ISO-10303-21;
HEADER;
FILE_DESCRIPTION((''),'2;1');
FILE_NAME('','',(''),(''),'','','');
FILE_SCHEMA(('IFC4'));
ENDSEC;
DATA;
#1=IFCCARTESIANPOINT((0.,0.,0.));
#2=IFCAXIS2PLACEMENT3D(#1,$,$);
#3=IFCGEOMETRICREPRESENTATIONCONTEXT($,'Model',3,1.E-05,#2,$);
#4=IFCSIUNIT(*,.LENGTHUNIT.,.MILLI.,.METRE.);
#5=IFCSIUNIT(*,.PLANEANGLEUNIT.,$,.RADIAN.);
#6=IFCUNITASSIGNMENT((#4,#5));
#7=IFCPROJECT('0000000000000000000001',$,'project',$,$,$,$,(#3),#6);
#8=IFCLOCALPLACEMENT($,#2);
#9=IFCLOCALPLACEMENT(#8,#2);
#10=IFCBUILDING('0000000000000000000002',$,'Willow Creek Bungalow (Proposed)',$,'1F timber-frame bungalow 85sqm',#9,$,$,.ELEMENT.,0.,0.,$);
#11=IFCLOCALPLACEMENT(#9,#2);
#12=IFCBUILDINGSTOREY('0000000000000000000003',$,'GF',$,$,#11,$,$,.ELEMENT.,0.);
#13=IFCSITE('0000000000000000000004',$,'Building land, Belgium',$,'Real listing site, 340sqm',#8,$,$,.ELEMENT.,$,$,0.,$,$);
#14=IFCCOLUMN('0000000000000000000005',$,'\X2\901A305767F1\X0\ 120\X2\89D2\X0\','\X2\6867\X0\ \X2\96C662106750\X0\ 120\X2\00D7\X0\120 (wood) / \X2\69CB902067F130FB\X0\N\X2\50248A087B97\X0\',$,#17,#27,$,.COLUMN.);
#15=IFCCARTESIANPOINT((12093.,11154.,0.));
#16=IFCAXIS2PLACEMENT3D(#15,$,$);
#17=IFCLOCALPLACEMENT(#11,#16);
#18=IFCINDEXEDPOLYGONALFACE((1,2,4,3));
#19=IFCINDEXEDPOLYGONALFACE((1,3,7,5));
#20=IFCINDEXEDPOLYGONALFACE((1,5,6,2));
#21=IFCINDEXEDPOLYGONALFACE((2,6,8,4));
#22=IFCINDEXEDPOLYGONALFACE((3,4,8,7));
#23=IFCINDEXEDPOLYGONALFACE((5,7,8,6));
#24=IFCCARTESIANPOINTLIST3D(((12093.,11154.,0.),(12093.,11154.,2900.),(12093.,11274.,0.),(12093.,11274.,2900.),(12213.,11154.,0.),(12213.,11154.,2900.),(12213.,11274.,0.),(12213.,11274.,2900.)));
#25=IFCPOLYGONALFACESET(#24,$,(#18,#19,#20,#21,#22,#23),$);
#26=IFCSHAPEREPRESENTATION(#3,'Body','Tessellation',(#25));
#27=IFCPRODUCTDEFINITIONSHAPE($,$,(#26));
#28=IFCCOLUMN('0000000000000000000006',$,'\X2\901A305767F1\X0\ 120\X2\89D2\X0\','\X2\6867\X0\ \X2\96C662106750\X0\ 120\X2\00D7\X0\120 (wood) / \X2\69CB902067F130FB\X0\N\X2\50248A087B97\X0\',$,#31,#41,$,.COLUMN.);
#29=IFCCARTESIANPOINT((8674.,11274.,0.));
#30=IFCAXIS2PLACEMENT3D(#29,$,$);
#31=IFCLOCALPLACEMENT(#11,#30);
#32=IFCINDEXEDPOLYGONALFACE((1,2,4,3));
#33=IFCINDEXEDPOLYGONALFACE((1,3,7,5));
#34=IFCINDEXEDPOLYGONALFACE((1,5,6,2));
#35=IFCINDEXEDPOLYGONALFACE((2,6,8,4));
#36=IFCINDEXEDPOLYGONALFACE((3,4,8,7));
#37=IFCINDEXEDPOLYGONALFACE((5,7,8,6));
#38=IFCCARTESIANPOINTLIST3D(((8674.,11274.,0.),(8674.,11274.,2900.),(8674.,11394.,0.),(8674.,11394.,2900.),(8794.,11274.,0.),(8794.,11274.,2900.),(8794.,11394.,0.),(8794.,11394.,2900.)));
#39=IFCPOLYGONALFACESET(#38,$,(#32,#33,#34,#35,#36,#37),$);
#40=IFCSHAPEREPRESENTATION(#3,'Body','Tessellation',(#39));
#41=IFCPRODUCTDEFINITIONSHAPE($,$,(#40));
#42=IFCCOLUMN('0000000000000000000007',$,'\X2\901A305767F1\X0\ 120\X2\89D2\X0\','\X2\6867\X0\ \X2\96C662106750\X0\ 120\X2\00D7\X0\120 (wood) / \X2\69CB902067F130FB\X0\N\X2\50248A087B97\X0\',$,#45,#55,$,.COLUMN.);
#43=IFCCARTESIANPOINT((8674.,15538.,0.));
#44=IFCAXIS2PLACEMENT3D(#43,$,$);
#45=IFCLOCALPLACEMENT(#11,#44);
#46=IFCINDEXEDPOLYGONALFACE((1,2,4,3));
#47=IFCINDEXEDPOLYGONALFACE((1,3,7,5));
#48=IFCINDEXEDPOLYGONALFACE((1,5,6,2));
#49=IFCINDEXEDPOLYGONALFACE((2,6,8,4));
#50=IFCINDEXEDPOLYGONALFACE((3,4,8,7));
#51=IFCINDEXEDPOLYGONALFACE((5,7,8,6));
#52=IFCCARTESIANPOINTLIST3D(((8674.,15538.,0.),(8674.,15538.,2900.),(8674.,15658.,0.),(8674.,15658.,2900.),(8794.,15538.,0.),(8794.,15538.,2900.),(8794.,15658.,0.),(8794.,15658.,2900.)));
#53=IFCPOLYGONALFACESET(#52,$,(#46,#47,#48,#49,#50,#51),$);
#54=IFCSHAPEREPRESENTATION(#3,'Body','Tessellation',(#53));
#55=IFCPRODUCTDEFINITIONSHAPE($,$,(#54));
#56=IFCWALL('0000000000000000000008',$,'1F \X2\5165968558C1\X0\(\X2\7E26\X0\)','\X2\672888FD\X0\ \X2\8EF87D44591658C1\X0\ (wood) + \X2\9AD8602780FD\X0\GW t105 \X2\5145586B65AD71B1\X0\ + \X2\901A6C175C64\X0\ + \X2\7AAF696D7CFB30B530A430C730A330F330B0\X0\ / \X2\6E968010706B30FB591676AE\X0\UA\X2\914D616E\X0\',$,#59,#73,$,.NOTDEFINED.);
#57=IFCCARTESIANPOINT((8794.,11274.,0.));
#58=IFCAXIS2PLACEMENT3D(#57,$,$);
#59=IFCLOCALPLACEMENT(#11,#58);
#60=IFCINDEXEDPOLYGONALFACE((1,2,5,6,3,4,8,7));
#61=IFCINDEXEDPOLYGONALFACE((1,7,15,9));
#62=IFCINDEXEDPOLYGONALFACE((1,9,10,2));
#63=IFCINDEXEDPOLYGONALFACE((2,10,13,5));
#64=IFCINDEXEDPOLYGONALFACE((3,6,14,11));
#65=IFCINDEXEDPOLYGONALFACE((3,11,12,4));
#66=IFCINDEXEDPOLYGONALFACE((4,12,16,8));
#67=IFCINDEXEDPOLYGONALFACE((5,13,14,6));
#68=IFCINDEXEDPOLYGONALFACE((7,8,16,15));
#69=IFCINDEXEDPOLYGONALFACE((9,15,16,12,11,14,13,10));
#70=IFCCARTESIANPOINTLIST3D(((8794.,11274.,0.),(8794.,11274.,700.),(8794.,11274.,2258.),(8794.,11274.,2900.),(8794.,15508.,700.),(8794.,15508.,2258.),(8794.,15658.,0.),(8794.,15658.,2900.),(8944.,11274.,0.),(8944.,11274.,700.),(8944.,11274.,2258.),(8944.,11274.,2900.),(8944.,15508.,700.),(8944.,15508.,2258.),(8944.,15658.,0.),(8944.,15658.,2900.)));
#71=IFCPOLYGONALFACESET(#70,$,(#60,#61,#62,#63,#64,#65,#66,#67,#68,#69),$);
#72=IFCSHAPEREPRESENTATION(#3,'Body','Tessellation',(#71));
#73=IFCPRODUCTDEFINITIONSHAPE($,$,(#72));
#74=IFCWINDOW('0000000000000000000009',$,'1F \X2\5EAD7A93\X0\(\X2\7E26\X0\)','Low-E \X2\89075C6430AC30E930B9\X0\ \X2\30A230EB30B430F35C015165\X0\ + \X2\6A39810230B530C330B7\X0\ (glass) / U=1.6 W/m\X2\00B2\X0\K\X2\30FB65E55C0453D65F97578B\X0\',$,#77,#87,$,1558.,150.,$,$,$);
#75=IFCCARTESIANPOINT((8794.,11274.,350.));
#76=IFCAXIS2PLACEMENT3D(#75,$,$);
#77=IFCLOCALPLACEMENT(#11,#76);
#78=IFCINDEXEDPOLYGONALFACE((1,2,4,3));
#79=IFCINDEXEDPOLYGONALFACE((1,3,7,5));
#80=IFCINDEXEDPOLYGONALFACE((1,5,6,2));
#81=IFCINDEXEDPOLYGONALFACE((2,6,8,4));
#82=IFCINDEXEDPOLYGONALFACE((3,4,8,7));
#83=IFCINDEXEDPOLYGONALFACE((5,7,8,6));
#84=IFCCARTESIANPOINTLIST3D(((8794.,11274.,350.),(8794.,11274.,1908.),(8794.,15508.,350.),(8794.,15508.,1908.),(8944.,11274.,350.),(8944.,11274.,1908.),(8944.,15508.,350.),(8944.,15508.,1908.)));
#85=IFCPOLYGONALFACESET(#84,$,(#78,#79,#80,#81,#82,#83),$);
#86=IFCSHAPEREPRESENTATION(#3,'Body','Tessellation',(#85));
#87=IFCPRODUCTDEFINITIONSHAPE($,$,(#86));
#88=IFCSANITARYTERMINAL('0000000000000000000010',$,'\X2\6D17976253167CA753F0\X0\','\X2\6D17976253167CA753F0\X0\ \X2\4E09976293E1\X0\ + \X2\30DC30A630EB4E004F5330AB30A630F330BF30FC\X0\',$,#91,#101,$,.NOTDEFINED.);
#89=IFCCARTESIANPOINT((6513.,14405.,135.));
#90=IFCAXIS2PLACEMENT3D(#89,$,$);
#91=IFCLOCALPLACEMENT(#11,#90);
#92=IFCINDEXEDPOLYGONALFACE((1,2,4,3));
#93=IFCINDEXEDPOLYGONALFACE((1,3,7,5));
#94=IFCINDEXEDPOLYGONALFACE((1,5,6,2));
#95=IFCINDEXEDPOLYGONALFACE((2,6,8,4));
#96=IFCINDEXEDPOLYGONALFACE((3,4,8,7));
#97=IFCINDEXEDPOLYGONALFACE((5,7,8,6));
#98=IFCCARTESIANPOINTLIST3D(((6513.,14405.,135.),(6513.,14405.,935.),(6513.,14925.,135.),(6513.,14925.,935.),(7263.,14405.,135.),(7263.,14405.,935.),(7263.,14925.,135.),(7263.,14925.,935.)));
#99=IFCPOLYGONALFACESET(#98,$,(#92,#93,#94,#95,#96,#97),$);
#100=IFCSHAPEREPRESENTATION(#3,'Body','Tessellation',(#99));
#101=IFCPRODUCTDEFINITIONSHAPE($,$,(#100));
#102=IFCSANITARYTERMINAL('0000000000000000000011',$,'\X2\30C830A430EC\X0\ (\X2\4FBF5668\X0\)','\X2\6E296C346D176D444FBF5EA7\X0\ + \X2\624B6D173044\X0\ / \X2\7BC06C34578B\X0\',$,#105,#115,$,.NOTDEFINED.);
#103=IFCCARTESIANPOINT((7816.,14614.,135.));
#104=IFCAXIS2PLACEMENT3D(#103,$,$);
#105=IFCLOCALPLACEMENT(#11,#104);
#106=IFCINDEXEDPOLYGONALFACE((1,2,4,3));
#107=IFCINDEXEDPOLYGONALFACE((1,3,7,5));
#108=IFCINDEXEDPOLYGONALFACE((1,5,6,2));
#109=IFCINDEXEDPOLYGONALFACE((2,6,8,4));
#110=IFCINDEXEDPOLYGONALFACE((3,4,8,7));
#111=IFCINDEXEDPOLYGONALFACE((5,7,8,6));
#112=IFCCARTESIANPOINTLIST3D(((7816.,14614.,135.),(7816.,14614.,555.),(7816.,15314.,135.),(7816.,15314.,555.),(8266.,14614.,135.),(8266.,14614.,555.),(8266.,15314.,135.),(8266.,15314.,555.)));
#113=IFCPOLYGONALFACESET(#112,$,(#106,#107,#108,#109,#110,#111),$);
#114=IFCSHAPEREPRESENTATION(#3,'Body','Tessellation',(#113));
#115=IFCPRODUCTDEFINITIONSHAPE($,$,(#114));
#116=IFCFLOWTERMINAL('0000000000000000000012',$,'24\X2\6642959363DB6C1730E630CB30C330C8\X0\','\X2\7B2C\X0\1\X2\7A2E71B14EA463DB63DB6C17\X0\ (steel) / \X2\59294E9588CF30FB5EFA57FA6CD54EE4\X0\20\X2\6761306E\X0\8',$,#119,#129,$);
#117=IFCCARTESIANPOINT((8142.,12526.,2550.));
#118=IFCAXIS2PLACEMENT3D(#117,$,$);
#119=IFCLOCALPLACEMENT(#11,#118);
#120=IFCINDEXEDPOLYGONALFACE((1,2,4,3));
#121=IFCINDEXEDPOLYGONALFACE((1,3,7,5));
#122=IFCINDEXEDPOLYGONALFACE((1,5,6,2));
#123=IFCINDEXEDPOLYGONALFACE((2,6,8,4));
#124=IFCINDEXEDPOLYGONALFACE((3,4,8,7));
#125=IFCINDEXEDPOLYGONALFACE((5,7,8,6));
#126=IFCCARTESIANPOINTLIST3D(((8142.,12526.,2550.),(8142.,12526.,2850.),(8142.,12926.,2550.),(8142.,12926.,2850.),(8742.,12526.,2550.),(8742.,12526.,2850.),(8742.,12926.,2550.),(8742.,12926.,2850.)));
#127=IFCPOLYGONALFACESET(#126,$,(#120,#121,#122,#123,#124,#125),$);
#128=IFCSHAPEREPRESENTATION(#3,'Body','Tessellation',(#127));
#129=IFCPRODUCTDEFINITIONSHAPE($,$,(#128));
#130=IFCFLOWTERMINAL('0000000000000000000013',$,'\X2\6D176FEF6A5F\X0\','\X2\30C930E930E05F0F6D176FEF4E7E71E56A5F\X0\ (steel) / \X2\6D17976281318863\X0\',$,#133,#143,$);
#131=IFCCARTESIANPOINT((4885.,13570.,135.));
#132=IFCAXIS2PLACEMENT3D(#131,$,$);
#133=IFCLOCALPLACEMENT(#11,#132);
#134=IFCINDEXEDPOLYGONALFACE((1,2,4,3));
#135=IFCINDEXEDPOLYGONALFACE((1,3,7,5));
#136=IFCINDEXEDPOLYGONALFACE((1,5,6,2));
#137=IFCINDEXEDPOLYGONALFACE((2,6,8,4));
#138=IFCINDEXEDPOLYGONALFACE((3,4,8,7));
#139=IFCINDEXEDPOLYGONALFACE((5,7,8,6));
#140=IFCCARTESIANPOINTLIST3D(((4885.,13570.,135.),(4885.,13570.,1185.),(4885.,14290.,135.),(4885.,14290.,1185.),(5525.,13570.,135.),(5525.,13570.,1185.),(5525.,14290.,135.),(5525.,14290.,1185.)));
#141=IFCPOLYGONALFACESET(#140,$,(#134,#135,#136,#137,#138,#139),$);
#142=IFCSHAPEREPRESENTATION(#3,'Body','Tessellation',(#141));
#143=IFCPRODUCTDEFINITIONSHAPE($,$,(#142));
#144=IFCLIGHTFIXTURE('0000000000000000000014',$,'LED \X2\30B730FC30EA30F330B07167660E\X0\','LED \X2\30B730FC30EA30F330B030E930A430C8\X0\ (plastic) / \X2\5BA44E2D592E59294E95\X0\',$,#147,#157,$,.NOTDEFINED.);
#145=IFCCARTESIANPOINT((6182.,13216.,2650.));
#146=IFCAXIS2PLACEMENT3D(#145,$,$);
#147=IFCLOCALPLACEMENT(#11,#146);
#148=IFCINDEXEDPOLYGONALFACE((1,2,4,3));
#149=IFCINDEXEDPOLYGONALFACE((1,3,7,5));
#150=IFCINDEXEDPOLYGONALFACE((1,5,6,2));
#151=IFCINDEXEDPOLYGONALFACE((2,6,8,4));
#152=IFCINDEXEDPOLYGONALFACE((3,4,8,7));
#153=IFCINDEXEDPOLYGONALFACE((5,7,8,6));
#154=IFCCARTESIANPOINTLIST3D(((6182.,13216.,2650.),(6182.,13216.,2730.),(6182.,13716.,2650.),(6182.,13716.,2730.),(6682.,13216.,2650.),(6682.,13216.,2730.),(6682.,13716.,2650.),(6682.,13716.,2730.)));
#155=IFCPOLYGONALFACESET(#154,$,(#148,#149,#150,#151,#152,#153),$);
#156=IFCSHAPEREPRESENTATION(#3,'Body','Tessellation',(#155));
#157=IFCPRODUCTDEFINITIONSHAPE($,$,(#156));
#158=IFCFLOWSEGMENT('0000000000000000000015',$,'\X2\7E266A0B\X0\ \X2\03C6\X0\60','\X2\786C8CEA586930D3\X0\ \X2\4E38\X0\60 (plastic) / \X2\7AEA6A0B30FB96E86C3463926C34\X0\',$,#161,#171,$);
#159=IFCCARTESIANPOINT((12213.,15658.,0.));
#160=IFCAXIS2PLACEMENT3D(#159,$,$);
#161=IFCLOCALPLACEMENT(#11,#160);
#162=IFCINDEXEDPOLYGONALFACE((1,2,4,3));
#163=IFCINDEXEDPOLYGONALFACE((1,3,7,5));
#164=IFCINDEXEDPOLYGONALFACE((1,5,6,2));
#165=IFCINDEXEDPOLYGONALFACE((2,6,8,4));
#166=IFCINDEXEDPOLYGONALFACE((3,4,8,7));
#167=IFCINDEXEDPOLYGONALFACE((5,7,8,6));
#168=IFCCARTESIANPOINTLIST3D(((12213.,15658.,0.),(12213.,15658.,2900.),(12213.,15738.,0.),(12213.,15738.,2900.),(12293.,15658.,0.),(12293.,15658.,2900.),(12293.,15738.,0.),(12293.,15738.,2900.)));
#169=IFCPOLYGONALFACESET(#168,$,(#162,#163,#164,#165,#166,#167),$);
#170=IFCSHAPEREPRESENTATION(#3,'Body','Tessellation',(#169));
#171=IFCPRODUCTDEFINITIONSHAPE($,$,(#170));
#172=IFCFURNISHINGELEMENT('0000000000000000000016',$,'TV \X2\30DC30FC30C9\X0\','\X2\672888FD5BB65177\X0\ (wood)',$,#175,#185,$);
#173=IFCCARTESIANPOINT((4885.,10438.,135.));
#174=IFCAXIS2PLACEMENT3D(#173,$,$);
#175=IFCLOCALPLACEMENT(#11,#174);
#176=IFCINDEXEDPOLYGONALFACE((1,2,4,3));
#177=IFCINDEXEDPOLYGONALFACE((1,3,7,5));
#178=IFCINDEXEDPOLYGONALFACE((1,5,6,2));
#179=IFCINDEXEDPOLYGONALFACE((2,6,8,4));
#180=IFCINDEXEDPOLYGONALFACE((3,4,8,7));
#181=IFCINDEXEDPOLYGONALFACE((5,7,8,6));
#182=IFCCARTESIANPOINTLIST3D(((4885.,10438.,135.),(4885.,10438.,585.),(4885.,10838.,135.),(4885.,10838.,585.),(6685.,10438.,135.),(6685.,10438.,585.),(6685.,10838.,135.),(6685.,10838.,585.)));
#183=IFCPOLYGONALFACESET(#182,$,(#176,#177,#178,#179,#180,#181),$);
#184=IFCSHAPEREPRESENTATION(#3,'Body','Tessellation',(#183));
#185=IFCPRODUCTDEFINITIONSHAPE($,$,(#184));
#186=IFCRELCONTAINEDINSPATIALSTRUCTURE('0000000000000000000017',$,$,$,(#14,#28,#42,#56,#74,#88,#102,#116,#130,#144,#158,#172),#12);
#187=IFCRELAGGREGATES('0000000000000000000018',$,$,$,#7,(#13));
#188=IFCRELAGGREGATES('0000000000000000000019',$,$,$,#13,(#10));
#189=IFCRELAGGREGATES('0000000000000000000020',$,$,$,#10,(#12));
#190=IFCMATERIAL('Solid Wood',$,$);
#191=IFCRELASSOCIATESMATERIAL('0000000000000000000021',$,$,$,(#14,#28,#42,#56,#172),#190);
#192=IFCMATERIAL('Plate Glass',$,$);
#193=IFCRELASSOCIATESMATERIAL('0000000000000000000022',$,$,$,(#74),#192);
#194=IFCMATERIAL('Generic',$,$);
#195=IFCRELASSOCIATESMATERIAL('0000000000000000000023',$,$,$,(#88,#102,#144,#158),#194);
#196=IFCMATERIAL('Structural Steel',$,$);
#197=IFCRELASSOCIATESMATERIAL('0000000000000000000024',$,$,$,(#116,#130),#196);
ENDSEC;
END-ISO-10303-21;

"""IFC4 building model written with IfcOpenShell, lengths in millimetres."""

from ifc_helpers import new_model, si_unit, frame, frame_2d, origin, place, context, project, spatial, rectangle, extrude, material, element, fill, save


model = new_model("IFC4")

# Units and contexts
model_context = context("Model", 3, precision=1e-05, world=origin())
ifc_project = project(units=[si_unit("LENGTHUNIT", "METRE", prefix="MILLI"), si_unit("PLANEANGLEUNIT", "RADIAN")], contexts=[model_context])

# Site, building, storey
site_placement = place(None, origin())
site = spatial("IfcSite", under=ifc_project, at=site_placement, Name="Building land, Belgium", ObjectType="Real listing site, 340sqm", CompositionType="ELEMENT", RefElevation=0.0)
building_placement = place(site_placement, origin())
building = spatial("IfcBuilding", under=site, at=building_placement, Name="Willow Creek Bungalow (Proposed)", ObjectType="1F timber-frame bungalow 85sqm", CompositionType="ELEMENT", ElevationOfRefHeight=0.0, ElevationOfTerrain=0.0)
storey_placement = place(building_placement, origin())
storey = spatial("IfcBuildingStorey", under=building, at=storey_placement, Name="GF", CompositionType="ELEMENT", Elevation=0.0)

# Columns
ifc_material_1 = material(Name="Solid Wood")
column_1_placement = place(storey_placement, frame((12093.0, 11154.0, 0.0)))
element("IfcColumn", 1, at=column_1_placement, inside=storey, material=ifc_material_1, Name="通し柱 120角", Description="桧 集成材 120×120 (wood) / 構造柱・N値計算", PredefinedType="COLUMN", context=model_context, shape_type="SweptSolid", body=[
    extrude(rectangle(XDim=120.0, YDim=120.0, at=frame_2d((60.0, 60.0))), frame((12093.0, 11154.0, 0.0)), (0.0, 0.0, 1.0), 2900.0),
])
column_2_placement = place(storey_placement, frame((8674.0, 11274.0, 0.0)))
element("IfcColumn", 2, at=column_2_placement, inside=storey, material=ifc_material_1, Name="通し柱 120角", Description="桧 集成材 120×120 (wood) / 構造柱・N値計算", PredefinedType="COLUMN", context=model_context, shape_type="SweptSolid", body=[
    extrude(rectangle(XDim=120.0, YDim=120.0, at=frame_2d((60.0, 60.0))), frame((8674.0, 11274.0, 0.0)), (0.0, 0.0, 1.0), 2900.0),
])
column_3_placement = place(storey_placement, frame((8674.0, 15538.0, 0.0)))
element("IfcColumn", 3, at=column_3_placement, inside=storey, material=ifc_material_1, Name="通し柱 120角", Description="桧 集成材 120×120 (wood) / 構造柱・N値計算", PredefinedType="COLUMN", context=model_context, shape_type="SweptSolid", body=[
    extrude(rectangle(XDim=120.0, YDim=120.0, at=frame_2d((60.0, 60.0))), frame((8674.0, 15538.0, 0.0)), (0.0, 0.0, 1.0), 2900.0),
])

# Wall, opening, window
wall_1_placement = place(storey_placement, frame((8794.0, 11274.0, 0.0)))
wall_1 = element("IfcWall", 4, at=wall_1_placement, inside=storey, material=ifc_material_1, Name="1F 入隅壁(縦)", Description="木製 軸組外壁 (wood) + 高性能GW t105 充填断熱 + 通気層 + 窯業系サイディング / 準耐火・外皮UA配慮", PredefinedType="NOTDEFINED", context=model_context, shape_type="SweptSolid", body=[
    extrude(rectangle(XDim=150.0, YDim=4384.0, at=frame_2d((75.0, 2192.0))), frame((8794.0, 11274.0, 0.0)), (0.0, 0.0, 1.0), 2900.0),
])
opening_placement = place(storey_placement, frame((8794.0, 11274.0, 350.0)))
opening = element("IfcOpeningElement", 5, at=opening_placement, cuts=wall_1, PredefinedType="NOTDEFINED", context=model_context, shape_type="SweptSolid", body=[
    extrude(rectangle(XDim=150.0, YDim=4234.0, at=frame_2d((75.0, 2117.0))), frame((8794.0, 11274.0, 350.0)), (0.0, 0.0, 1.0), 1558.0),
])
ifc_material_2 = material(Name="Plate Glass")
window_placement = place(storey_placement, frame((8794.0, 11274.0, 350.0)))
window = element("IfcWindow", 6, at=window_placement, inside=storey, material=ifc_material_2, Name="1F 庭窓(縦)", Description="Low-E 複層ガラス アルゴン封入 + 樹脂サッシ (glass) / U=1.6 W/m²K・日射取得型", OverallHeight=1558.0, OverallWidth=150.0, context=model_context, shape_type="SweptSolid", body=[
    extrude(rectangle(XDim=150.0, YDim=4234.0, at=frame_2d((75.0, 2117.0))), frame((8794.0, 11274.0, 350.0)), (0.0, 0.0, 1.0), 1558.0),
])
fill(opening, window)

# Sanitary terminals
ifc_material_3 = material(Name="Generic")
sanitary_terminal_1_placement = place(storey_placement, frame((6513.0, 14405.0, 135.0)))
element("IfcSanitaryTerminal", 7, at=sanitary_terminal_1_placement, inside=storey, material=ifc_material_3, Name="洗面化粧台", Description="洗面化粧台 三面鏡 + ボウル一体カウンター", PredefinedType="NOTDEFINED", context=model_context, shape_type="SweptSolid", body=[
    extrude(rectangle(XDim=750.0, YDim=520.0, at=frame_2d((375.0, 260.0))), frame((6513.0, 14405.0, 135.0)), (0.0, 0.0, 1.0), 800.0),
])
sanitary_terminal_2_placement = place(storey_placement, frame((7816.0, 14614.0, 135.0)))
element("IfcSanitaryTerminal", 8, at=sanitary_terminal_2_placement, inside=storey, material=ifc_material_3, Name="トイレ (便器)", Description="温水洗浄便座 + 手洗い / 節水型", PredefinedType="NOTDEFINED", context=model_context, shape_type="SweptSolid", body=[
    extrude(rectangle(XDim=450.0, YDim=700.0, at=frame_2d((225.0, 350.0))), frame((7816.0, 14614.0, 135.0)), (0.0, 0.0, 1.0), 420.0),
])

# Flow terminals
ifc_material_4 = material(Name="Structural Steel")
flow_terminal_1_placement = place(storey_placement, frame((8142.0, 12526.0, 2550.0)))
element("IfcFlowTerminal", 9, at=flow_terminal_1_placement, inside=storey, material=ifc_material_4, Name="24時間換気ユニット", Description="第1種熱交換換気 (steel) / 天井裏・建基法令20条の8", context=model_context, shape_type="SweptSolid", body=[
    extrude(rectangle(XDim=600.0, YDim=400.0, at=frame_2d((300.0, 200.0))), frame((8142.0, 12526.0, 2550.0)), (0.0, 0.0, 1.0), 300.0),
])
flow_terminal_2_placement = place(storey_placement, frame((4885.0, 13570.0, 135.0)))
element("IfcFlowTerminal", 10, at=flow_terminal_2_placement, inside=storey, material=ifc_material_4, Name="洗濯機", Description="ドラム式洗濯乾燥機 (steel) / 洗面脱衣", context=model_context, shape_type="SweptSolid", body=[
    extrude(rectangle(XDim=640.0, YDim=720.0, at=frame_2d((320.0, 360.0))), frame((4885.0, 13570.0, 135.0)), (0.0, 0.0, 1.0), 1050.0),
])

# Light fixture
light_fixture_placement = place(storey_placement, frame((6182.0, 13216.0, 2650.0)))
element("IfcLightFixture", 11, at=light_fixture_placement, inside=storey, material=ifc_material_3, Name="LED シーリング照明", Description="LED シーリングライト (plastic) / 室中央天井", PredefinedType="NOTDEFINED", context=model_context, shape_type="SweptSolid", body=[
    extrude(rectangle(XDim=500.0, YDim=500.0, at=frame_2d((250.0, 250.0))), frame((6182.0, 13216.0, 2650.0)), (0.0, 0.0, 1.0), 80.0),
])

# Flow segment
flow_segment_placement = place(storey_placement, frame((12213.0, 15658.0, 0.0)))
element("IfcFlowSegment", 12, at=flow_segment_placement, inside=storey, material=ifc_material_3, Name="縦樋 φ60", Description="硬質塩ビ 丸60 (plastic) / 竪樋・雨水排水", context=model_context, shape_type="SweptSolid", body=[
    extrude(rectangle(XDim=80.0, YDim=80.0, at=frame_2d((40.0, 40.0))), frame((12213.0, 15658.0, 0.0)), (0.0, 0.0, 1.0), 2900.0),
])

# Furnishing element
furnishing_placement = place(storey_placement, frame((4885.0, 10438.0, 135.0)))
element("IfcFurnishingElement", 13, at=furnishing_placement, inside=storey, material=ifc_material_1, Name="TV ボード", Description="木製家具 (wood)", context=model_context, shape_type="SweptSolid", body=[
    extrude(rectangle(XDim=1800.0, YDim=400.0, at=frame_2d((900.0, 200.0))), frame((4885.0, 10438.0, 135.0)), (0.0, 0.0, 1.0), 450.0),
])

save(model, "model.ifc")
